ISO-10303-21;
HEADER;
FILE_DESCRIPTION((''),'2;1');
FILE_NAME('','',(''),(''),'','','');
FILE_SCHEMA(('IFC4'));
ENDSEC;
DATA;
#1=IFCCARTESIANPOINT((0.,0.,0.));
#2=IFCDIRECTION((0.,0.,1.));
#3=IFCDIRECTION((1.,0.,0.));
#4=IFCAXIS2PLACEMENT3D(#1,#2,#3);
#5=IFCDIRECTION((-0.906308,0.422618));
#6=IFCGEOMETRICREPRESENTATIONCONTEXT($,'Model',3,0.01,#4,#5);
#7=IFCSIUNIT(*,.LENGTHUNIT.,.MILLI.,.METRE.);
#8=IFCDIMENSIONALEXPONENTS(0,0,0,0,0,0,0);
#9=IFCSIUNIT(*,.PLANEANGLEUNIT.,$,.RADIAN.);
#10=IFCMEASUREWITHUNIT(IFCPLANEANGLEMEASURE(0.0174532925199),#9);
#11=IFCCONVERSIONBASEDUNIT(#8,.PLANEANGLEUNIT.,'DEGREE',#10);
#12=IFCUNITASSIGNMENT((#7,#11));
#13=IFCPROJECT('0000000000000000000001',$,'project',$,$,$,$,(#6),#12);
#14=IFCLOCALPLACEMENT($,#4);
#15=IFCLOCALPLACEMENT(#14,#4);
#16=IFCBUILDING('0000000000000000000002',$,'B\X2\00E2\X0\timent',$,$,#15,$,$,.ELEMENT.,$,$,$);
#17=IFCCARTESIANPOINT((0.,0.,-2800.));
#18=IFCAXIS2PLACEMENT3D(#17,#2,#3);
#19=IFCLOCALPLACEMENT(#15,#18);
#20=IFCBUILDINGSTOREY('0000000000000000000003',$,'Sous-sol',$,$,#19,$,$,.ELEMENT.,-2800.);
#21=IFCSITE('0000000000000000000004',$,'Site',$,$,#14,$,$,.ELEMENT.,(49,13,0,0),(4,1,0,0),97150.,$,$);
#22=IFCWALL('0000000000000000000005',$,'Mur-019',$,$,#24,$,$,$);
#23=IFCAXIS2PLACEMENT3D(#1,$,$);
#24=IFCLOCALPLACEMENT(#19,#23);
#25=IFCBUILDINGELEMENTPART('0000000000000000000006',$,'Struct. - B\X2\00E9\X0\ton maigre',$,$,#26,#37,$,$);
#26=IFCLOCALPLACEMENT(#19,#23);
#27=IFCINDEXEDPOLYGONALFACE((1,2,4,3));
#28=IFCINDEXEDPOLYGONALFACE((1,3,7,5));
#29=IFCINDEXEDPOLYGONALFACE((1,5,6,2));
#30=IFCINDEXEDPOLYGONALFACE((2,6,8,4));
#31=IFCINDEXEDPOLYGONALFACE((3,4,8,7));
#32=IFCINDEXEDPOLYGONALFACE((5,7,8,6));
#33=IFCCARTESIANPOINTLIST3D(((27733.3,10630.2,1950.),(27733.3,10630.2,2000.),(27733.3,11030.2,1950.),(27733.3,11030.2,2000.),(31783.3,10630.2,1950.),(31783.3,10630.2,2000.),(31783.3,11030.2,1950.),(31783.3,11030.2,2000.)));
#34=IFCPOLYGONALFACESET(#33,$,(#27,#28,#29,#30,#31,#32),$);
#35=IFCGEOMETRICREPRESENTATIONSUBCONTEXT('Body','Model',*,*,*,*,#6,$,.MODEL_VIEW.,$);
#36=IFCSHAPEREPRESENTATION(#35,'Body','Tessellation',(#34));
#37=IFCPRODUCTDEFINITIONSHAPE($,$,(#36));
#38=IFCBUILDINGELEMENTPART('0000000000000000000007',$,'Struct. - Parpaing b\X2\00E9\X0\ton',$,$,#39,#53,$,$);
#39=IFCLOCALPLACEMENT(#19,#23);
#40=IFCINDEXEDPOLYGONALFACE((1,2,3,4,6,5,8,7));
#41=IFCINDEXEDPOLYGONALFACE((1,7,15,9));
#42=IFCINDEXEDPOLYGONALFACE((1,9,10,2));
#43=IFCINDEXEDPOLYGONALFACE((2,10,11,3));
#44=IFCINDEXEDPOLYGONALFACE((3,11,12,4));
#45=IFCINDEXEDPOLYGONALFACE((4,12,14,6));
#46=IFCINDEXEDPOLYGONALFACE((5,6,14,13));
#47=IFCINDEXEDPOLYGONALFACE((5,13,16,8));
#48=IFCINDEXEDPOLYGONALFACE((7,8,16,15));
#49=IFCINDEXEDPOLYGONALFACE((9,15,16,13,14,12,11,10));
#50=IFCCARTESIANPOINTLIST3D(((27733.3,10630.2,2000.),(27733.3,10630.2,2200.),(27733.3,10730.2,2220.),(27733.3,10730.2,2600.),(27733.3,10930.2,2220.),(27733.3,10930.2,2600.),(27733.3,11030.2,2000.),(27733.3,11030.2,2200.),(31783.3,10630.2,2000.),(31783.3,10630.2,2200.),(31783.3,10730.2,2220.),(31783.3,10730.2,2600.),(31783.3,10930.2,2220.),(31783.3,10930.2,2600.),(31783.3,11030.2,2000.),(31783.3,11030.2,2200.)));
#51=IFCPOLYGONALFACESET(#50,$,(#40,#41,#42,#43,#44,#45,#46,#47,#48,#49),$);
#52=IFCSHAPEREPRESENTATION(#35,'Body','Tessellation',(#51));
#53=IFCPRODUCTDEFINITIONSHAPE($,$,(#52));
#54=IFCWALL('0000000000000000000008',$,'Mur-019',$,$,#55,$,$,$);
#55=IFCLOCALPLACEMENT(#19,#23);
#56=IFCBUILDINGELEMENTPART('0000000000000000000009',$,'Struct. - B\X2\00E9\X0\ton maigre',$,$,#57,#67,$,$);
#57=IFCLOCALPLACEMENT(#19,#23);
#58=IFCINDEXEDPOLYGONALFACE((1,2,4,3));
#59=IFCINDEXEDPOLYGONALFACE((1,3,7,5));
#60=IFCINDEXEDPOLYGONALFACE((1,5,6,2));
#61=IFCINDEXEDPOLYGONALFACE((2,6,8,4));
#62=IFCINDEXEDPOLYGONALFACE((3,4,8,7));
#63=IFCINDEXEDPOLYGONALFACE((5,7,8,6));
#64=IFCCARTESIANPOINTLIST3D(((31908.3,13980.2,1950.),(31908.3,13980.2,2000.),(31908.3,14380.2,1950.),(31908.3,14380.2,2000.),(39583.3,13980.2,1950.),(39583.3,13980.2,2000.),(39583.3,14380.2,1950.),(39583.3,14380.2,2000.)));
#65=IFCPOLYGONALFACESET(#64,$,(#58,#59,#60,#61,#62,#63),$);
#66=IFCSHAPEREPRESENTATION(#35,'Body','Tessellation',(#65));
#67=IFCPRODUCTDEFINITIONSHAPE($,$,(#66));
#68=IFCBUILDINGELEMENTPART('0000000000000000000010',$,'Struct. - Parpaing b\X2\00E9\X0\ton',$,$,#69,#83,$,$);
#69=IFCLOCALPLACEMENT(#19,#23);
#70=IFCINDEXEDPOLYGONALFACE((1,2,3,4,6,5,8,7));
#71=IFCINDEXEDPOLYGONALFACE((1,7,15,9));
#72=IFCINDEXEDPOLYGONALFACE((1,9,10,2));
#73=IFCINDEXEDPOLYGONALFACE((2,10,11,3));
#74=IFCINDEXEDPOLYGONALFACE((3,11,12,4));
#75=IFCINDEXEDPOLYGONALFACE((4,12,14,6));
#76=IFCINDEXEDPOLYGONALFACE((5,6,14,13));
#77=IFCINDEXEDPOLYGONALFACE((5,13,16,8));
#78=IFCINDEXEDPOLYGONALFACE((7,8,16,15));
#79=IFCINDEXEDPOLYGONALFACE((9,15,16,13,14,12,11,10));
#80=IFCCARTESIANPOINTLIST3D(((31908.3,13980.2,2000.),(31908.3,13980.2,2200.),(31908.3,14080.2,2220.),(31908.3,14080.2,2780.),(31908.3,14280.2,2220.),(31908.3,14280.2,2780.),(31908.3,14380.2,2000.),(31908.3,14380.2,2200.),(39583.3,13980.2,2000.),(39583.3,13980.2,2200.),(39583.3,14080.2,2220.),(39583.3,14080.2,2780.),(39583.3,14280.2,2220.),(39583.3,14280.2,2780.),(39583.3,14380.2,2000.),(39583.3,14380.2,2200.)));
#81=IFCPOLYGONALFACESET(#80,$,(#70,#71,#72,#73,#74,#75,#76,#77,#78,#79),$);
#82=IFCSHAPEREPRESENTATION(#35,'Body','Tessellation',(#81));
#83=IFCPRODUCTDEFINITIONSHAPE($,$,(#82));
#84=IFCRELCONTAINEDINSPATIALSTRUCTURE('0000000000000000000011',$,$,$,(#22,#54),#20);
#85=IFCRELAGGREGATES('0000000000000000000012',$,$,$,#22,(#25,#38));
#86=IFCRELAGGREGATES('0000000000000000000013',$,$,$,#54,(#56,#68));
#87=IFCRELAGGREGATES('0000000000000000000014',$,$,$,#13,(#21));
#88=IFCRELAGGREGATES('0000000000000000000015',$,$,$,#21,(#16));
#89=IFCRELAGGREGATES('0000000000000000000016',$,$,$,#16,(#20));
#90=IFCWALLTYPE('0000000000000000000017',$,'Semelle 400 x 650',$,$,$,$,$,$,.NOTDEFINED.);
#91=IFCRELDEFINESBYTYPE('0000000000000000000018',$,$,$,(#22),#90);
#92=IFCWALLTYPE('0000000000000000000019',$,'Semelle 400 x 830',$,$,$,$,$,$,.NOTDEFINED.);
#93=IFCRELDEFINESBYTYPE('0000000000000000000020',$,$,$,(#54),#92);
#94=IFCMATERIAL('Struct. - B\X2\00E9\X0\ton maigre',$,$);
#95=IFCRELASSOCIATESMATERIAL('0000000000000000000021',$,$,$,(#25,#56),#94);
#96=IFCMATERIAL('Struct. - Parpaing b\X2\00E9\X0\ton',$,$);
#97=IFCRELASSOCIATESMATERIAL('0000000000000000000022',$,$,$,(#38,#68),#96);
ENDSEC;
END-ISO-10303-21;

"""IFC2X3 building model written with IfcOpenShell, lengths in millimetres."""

from ifc_helpers import new_model, entity, si_unit, converted_unit, direction, frame, origin_with_axes, place, context, subcontext, project, spatial, polyline, outline, extrude, material, type_object, element, aggregate, save


model = new_model("IFC2X3")

# Units and contexts
model_context = context("Model", 3, precision=0.01, world=origin_with_axes(), true_north=direction((-0.906308, 0.422618)))
body_context = subcontext(model_context, "Body", "Model", "MODEL_VIEW")
ifc_project = project(units=[si_unit("LENGTHUNIT", "METRE", prefix="MILLI"), converted_unit("PLANEANGLEUNIT", "DEGREE", entity("IfcPlaneAngleMeasure", 0.0174532925199), si_unit("PLANEANGLEUNIT", "RADIAN"), dimensions=[0, 0, 0, 0, 0, 0, 0])], contexts=[model_context])

# Site, building, storey
site_placement = place(None, origin_with_axes())
site = spatial("IfcSite", under=ifc_project, at=site_placement, Name="Site", CompositionType="ELEMENT", RefLatitude=(49, 13, 0, 0), RefLongitude=(4, 1, 0, 0), RefElevation=97150.0)
building_placement = place(site_placement, origin_with_axes())
building = spatial("IfcBuilding", under=site, at=building_placement, Name="Bâtiment", CompositionType="ELEMENT")
storey_placement = place(building_placement, frame((0.0, 0.0, -2800.0), z_axis=(0.0, 0.0, 1.0), x_axis=(1.0, 0.0, 0.0)))
storey = spatial("IfcBuildingStorey", under=building, at=storey_placement, Name="Sous-sol", CompositionType="ELEMENT", Elevation=-2800.0)

# Walls, building element parts
ifc_material_1 = material(Name="Struct. - Béton maigre")
ifc_material_2 = material(Name="Struct. - Parpaing béton")
wall_type_1 = type_object("IfcWallType", Name="Semelle 400 x 650", PredefinedType="NOTDEFINED")
wall_1_placement = place(storey_placement, frame((31783.3, 10830.2, 2000.0), z_axis=(0.0, 0.0, 1.0), x_axis=(-1.0, 0.0, 0.0)))
wall_1 = element("IfcWall", 1, at=wall_1_placement, inside=storey, type_object=wall_type_1, Name="Mur-019")
building_element_part_1_placement = place(wall_1_placement, origin_with_axes())
building_element_part_1 = element("IfcBuildingElementPart", 2, at=building_element_part_1_placement, material=ifc_material_1, Name="Struct. - Béton maigre", context=body_context, shape_type="SweptSolid", body=[
    extrude(outline(polyline([(-200.0, 0.0), (-200.0, -50.0), (200.0, -50.0), (200.0, 0.0), (-200.0, 0.0)])), frame((0.0, 0.0, 0.0), z_axis=(-1.0, 0.0, 0.0), x_axis=(0.0, -1.0, 0.0)), (0.0, 0.0, -1.0), 4050.0),
])
building_element_part_2_placement = place(wall_1_placement, origin_with_axes())
building_element_part_2 = element("IfcBuildingElementPart", 3, at=building_element_part_2_placement, material=ifc_material_2, Name="Struct. - Parpaing béton", context=body_context, shape_type="SweptSolid", body=[
    extrude(outline(polyline([(-200.0, 200.0), (-200.0, 0.0), (200.0, 0.0), (200.0, 200.0), (100.0, 220.0), (100.0, 600.0), (-100.0, 600.0), (-100.0, 220.0), (-200.0, 200.0)])), frame((0.0, 0.0, 0.0), z_axis=(-1.0, 0.0, 0.0), x_axis=(0.0, -1.0, 0.0)), (0.0, 0.0, -1.0), 4050.0),
])
aggregate(wall_1, [building_element_part_1, building_element_part_2])
wall_type_2 = type_object("IfcWallType", Name="Semelle 400 x 830", PredefinedType="NOTDEFINED")
wall_2_placement = place(storey_placement, frame((31908.3, 14180.2, 2000.0), z_axis=(0.0, 0.0, 1.0), x_axis=(1.0, 0.0, 0.0)))
wall_2 = element("IfcWall", 4, at=wall_2_placement, inside=storey, type_object=wall_type_2, Name="Mur-019")
building_element_part_3_placement = place(wall_2_placement, origin_with_axes())
building_element_part_3 = element("IfcBuildingElementPart", 5, at=building_element_part_3_placement, material=ifc_material_1, Name="Struct. - Béton maigre", context=body_context, shape_type="SweptSolid", body=[
    extrude(outline(polyline([(-200.0, 0.0), (-200.0, -50.0), (200.0, -50.0), (200.0, 0.0), (-200.0, 0.0)])), frame((0.0, 0.0, 0.0), z_axis=(-1.0, 0.0, 0.0), x_axis=(0.0, -1.0, 0.0)), (0.0, 0.0, -1.0), 7675.0),
])
building_element_part_4_placement = place(wall_2_placement, origin_with_axes())
building_element_part_4 = element("IfcBuildingElementPart", 6, at=building_element_part_4_placement, material=ifc_material_2, Name="Struct. - Parpaing béton", context=body_context, shape_type="SweptSolid", body=[
    extrude(outline(polyline([(-200.0, 200.0), (-200.0, 0.0), (200.0, 0.0), (200.0, 200.0), (100.0, 220.0), (100.0, 780.0), (-100.0, 780.0), (-100.0, 220.0), (-200.0, 200.0)])), frame((0.0, 0.0, 0.0), z_axis=(-1.0, 0.0, 0.0), x_axis=(0.0, -1.0, 0.0)), (0.0, 0.0, -1.0), 7675.0),
])
aggregate(wall_2, [building_element_part_3, building_element_part_4])

save(model, "model.ifc")
